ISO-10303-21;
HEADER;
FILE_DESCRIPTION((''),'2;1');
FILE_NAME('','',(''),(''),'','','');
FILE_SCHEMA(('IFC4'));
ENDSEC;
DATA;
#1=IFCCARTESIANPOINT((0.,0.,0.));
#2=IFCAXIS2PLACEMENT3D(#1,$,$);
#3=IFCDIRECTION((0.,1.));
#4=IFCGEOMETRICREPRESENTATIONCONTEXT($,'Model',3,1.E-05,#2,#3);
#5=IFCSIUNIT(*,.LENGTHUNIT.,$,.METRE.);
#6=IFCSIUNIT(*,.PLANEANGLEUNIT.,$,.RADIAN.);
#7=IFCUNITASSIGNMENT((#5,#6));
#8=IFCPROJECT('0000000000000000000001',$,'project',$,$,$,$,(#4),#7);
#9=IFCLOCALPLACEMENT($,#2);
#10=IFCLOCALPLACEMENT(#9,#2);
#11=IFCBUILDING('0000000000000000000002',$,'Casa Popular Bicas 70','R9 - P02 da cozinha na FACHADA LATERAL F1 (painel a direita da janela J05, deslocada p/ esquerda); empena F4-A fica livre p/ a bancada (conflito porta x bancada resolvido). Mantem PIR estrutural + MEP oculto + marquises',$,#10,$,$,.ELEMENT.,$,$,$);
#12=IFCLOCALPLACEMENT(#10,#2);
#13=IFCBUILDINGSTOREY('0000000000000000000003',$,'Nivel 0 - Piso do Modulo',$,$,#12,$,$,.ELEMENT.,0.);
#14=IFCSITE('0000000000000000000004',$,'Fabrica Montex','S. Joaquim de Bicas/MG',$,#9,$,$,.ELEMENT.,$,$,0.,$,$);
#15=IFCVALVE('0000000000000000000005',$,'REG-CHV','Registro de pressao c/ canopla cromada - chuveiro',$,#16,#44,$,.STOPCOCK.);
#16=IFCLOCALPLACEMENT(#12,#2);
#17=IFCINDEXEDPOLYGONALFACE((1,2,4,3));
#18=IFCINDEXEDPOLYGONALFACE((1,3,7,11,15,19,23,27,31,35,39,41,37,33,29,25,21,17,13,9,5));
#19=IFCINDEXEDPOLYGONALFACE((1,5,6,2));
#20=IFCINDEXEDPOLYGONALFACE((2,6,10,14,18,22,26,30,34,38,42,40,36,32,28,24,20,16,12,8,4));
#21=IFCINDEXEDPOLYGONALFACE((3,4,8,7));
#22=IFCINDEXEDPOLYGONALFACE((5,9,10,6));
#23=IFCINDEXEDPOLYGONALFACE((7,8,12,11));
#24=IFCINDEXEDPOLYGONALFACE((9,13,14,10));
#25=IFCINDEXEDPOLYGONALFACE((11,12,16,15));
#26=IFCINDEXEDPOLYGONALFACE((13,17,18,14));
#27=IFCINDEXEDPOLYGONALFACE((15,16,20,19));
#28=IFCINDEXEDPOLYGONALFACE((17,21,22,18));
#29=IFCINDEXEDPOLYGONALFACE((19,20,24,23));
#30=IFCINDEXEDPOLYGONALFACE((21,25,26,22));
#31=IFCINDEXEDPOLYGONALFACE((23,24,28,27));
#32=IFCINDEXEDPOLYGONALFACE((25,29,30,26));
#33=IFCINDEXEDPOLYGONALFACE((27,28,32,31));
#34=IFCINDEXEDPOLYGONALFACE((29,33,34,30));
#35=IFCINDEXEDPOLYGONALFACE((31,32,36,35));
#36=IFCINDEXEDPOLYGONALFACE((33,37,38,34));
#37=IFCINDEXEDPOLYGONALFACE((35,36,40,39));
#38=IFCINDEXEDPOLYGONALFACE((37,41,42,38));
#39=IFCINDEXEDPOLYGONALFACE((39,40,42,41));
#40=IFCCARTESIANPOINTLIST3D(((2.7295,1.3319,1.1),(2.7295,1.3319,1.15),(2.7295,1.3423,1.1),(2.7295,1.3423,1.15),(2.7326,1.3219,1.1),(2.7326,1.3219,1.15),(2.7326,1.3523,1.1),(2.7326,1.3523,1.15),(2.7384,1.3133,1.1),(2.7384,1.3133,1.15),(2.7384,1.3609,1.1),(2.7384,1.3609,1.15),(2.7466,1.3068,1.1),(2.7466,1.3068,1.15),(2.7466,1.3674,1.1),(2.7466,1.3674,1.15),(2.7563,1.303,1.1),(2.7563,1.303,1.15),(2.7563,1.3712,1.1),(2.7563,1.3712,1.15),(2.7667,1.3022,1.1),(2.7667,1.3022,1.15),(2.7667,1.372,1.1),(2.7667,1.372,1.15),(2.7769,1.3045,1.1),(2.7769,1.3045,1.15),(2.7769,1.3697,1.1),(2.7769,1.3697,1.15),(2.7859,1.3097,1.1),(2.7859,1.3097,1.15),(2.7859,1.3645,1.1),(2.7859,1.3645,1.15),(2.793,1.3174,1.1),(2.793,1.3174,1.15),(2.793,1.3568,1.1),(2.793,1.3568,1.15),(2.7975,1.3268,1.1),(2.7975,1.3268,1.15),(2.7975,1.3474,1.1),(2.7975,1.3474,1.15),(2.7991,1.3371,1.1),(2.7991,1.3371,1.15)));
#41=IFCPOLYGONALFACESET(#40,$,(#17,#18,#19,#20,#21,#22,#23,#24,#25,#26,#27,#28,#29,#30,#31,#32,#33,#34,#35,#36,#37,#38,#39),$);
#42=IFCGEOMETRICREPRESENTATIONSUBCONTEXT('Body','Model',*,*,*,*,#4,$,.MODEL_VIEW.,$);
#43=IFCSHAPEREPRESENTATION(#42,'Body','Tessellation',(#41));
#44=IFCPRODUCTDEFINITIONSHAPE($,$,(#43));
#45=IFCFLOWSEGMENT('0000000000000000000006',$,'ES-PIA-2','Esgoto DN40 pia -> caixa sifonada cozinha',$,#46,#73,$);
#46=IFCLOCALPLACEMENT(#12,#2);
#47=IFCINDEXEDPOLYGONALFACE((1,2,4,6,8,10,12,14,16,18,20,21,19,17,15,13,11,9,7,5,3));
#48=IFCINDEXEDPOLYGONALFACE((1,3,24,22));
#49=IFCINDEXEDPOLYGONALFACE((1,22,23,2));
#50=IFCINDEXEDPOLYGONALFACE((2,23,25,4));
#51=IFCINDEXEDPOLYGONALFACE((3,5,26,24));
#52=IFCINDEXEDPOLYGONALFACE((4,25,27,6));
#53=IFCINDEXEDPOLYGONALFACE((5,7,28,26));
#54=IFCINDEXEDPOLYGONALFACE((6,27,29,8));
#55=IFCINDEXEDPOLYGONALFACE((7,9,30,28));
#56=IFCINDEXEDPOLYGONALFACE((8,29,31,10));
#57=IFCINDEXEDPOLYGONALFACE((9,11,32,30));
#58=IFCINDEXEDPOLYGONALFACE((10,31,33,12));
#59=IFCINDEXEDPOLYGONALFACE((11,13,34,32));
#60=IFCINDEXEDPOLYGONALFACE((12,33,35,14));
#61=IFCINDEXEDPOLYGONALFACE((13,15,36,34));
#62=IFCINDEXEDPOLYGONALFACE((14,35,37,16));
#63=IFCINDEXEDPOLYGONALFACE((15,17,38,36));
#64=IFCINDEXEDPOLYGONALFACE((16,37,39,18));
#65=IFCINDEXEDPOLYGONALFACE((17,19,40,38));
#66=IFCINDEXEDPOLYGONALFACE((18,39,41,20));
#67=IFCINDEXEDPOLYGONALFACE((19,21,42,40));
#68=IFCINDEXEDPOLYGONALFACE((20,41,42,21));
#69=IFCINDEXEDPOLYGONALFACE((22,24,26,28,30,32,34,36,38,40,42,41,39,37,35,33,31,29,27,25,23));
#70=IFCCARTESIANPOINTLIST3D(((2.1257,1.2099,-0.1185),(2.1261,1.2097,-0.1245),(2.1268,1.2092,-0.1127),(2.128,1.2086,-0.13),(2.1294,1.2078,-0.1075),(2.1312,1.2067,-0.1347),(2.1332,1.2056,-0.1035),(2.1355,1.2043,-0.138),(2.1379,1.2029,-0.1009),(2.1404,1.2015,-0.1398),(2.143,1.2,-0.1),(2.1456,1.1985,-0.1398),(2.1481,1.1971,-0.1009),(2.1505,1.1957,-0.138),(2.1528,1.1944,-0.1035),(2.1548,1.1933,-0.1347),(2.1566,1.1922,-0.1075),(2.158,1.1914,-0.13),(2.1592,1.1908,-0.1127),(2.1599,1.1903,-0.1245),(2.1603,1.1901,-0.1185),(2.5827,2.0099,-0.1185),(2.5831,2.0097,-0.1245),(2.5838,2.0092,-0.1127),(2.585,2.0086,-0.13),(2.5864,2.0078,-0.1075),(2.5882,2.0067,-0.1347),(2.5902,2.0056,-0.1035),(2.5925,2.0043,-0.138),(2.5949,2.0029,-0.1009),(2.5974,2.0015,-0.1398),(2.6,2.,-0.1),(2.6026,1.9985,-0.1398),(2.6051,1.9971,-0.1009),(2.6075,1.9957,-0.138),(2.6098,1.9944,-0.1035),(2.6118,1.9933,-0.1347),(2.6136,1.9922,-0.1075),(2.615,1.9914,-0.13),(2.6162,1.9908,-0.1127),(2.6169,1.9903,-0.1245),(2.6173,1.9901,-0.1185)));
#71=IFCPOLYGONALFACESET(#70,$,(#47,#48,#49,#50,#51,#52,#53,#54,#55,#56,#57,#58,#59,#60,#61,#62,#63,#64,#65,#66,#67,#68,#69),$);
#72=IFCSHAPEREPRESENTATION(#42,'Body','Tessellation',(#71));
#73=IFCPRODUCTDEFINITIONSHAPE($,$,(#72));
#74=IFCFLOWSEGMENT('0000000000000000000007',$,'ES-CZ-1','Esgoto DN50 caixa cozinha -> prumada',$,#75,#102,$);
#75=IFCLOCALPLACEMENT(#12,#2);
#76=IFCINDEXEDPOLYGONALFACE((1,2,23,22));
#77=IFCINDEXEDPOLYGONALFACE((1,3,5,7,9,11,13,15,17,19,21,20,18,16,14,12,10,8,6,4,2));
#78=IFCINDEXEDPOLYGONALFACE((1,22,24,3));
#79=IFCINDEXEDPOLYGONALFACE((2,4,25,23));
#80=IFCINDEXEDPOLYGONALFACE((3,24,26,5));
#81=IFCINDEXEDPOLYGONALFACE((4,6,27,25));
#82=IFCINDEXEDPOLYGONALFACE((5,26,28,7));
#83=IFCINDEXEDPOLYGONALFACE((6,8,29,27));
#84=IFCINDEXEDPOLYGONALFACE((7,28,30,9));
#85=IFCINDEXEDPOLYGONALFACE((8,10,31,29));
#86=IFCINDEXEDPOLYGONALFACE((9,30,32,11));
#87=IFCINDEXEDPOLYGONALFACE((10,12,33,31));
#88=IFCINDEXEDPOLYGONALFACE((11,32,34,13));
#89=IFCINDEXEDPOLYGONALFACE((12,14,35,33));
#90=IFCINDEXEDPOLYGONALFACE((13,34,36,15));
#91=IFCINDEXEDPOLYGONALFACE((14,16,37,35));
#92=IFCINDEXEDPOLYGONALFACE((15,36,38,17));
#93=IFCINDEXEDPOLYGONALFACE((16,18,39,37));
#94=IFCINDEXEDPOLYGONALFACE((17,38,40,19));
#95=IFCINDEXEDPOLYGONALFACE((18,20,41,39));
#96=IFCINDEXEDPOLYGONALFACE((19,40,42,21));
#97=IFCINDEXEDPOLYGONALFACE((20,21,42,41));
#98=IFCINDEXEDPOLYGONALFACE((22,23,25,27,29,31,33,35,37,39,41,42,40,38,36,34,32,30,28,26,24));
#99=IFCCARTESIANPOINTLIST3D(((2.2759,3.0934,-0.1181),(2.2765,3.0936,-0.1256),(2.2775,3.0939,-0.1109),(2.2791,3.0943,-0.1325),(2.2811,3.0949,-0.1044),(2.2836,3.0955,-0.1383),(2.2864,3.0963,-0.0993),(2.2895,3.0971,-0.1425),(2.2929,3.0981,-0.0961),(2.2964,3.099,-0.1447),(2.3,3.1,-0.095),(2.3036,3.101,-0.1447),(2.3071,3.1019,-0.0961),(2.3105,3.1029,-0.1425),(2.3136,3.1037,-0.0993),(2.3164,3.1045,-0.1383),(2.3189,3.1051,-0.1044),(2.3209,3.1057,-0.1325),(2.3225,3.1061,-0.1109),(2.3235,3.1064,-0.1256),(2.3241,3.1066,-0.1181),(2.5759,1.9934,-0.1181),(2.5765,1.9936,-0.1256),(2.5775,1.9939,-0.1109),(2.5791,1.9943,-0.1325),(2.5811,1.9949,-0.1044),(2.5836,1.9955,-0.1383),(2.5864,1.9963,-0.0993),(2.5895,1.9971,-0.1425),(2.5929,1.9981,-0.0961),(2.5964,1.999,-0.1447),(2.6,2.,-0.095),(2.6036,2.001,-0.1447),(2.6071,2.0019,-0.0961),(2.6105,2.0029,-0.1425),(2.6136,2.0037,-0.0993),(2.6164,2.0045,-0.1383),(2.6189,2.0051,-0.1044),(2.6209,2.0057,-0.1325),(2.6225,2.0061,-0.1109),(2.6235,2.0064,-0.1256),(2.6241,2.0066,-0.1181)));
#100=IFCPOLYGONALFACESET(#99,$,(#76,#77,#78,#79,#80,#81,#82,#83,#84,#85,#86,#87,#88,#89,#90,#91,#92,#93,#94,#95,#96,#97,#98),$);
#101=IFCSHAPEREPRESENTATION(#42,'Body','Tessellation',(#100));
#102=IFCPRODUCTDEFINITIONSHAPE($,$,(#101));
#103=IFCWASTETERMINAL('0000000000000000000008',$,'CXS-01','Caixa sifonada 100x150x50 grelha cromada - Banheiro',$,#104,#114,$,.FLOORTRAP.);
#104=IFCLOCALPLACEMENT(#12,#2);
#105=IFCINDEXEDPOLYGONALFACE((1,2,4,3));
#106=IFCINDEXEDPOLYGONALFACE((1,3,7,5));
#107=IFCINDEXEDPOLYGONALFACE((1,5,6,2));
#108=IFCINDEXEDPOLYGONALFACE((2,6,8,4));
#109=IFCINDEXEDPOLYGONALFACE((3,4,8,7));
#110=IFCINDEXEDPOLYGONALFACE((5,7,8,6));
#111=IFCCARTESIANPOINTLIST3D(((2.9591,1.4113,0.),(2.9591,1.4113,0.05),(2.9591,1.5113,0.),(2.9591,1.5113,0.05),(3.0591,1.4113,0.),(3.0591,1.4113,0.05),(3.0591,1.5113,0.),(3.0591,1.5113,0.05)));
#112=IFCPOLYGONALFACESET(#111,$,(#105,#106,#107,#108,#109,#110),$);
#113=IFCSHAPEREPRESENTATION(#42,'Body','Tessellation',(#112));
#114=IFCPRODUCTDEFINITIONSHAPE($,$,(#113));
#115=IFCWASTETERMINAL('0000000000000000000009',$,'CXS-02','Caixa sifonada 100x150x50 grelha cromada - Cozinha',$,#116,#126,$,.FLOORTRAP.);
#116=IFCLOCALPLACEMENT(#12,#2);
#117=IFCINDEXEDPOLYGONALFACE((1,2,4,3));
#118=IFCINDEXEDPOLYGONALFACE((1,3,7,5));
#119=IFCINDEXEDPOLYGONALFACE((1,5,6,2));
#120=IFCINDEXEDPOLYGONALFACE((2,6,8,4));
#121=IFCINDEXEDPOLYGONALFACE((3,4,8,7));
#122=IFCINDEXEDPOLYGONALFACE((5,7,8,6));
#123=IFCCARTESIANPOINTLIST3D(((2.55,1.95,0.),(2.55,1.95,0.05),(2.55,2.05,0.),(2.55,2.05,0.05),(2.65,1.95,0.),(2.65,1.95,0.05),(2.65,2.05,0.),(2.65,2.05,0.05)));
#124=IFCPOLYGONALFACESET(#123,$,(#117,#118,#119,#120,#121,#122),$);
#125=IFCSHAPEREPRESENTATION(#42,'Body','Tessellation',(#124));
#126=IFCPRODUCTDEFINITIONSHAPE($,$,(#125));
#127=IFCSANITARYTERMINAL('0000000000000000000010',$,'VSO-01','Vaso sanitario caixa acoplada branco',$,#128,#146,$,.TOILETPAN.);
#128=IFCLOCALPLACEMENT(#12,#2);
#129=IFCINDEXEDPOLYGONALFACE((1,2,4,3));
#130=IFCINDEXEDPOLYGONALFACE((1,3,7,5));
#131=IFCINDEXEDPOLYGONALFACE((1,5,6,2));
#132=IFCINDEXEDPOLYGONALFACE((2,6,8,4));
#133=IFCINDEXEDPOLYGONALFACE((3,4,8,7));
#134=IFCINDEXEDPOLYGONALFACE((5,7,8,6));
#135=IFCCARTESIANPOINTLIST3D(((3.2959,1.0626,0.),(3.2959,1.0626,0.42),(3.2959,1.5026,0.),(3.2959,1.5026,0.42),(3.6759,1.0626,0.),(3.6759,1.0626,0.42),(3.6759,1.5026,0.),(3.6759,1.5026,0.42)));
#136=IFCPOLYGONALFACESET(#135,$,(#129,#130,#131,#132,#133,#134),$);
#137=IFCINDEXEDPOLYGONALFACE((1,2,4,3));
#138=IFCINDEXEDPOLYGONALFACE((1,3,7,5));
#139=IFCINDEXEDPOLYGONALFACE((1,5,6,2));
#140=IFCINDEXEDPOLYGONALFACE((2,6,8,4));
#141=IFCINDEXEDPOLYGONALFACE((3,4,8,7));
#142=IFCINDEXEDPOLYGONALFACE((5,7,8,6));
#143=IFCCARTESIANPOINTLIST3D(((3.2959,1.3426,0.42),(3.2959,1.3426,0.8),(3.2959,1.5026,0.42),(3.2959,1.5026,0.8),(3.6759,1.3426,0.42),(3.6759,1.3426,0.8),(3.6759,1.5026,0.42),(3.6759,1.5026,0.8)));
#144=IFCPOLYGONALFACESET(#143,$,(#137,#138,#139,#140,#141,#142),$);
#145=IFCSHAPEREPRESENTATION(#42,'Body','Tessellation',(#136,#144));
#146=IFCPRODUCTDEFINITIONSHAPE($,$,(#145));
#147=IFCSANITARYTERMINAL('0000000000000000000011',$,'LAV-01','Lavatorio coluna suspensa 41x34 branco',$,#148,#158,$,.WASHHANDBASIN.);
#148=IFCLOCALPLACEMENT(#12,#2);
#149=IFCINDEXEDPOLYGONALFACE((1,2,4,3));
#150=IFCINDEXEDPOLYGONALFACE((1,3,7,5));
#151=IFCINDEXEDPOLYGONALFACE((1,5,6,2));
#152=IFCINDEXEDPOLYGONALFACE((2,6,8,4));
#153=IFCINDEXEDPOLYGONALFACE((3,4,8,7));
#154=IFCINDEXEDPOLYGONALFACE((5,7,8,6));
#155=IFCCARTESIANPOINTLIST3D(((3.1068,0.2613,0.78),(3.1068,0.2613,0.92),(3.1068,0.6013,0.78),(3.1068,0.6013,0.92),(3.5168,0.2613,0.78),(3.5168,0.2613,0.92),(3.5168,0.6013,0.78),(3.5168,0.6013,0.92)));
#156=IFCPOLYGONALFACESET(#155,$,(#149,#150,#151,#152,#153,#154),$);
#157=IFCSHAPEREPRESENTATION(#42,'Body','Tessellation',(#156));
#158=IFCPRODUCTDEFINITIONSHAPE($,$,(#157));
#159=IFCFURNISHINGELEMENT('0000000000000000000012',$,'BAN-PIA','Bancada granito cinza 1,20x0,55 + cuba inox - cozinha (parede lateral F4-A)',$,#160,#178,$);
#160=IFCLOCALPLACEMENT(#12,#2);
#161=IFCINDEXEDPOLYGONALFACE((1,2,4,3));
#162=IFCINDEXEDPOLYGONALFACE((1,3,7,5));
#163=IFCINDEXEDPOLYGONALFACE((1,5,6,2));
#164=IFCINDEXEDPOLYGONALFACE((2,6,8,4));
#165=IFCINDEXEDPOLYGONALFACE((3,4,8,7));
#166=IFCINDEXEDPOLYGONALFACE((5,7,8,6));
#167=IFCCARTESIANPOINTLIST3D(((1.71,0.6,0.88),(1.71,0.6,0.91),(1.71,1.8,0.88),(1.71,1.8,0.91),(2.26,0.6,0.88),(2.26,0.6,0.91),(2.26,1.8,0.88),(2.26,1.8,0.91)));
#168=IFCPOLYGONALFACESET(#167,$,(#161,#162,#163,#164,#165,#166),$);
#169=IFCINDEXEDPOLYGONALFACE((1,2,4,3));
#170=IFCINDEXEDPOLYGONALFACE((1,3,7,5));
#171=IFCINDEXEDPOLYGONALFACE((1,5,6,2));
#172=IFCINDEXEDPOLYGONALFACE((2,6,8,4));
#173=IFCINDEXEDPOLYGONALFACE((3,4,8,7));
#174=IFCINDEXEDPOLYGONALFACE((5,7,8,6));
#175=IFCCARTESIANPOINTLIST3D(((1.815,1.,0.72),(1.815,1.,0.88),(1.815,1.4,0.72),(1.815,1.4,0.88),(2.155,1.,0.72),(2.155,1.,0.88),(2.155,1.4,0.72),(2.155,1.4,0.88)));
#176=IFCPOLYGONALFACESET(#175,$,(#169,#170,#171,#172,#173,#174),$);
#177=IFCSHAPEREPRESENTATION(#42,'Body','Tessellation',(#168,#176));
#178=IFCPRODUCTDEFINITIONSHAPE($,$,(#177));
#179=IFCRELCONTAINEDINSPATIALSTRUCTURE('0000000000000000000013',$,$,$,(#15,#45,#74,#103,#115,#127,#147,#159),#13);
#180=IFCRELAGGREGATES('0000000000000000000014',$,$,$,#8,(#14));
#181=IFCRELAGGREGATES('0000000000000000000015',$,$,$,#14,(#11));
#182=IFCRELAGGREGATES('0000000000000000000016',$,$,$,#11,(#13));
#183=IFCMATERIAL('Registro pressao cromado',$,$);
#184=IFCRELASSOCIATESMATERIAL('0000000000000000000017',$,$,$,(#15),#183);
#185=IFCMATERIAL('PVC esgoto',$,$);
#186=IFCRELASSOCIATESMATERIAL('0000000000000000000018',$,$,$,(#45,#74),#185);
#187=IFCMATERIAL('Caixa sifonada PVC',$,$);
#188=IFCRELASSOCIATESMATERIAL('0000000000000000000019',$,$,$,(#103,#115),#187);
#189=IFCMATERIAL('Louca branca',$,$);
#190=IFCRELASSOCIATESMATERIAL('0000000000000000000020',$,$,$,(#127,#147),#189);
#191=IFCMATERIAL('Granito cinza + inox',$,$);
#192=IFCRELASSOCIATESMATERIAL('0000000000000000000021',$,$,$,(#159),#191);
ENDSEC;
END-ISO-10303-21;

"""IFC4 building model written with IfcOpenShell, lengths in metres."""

from ifc_helpers import new_model, si_unit, direction, frame, frame_2d, origin, origin_2d, place, context, subcontext, project, spatial, rectangle, circle, extrude, material, element, save


model = new_model("IFC4")

# Units and contexts
model_context = context("Model", 3, precision=1e-05, world=origin(), true_north=direction((0.0, 1.0)))
body_context = subcontext(model_context, "Body", "Model", "MODEL_VIEW")
ifc_project = project(units=[si_unit("LENGTHUNIT", "METRE"), si_unit("PLANEANGLEUNIT", "RADIAN")], contexts=[model_context])

# Site, building, storey
site_placement = place(None, origin())
site = spatial("IfcSite", under=ifc_project, at=site_placement, Name="Fabrica Montex", Description="S. Joaquim de Bicas/MG", CompositionType="ELEMENT", RefElevation=0.0)
building_placement = place(site_placement, origin())
building = spatial("IfcBuilding", under=site, at=building_placement, Name="Casa Popular Bicas 70", Description="R9 - P02 da cozinha na FACHADA LATERAL F1 (painel a direita da janela J05, deslocada p/ esquerda); empena F4-A fica livre p/ a bancada (conflito porta x bancada resolvido). Mantem PIR estrutural + MEP oculto + marquises", CompositionType="ELEMENT")
storey_placement = place(building_placement, origin())
storey = spatial("IfcBuildingStorey", under=building, at=storey_placement, Name="Nivel 0 - Piso do Modulo", CompositionType="ELEMENT", Elevation=0.0)

# Valve
ifc_material_1 = material(Name="Registro pressao cromado")
valve_placement = place(storey_placement, frame((2.7641, 1.3371, 1.1)))
element("IfcValve", 1, at=valve_placement, inside=storey, material=ifc_material_1, Name="REG-CHV", Description="Registro de pressao c/ canopla cromada - chuveiro", PredefinedType="STOPCOCK", context=body_context, shape_type="SweptSolid", body=[
    extrude(circle(Radius=0.035, at=origin_2d()), origin(), (0.0, 0.0, 1.0), 0.05),
])

# Flow segments
ifc_material_2 = material(Name="PVC esgoto")
flow_segment_1_placement = place(storey_placement, frame((2.143, 1.2, -0.12), z_axis=(0.496022, 0.86831, 0.0), x_axis=(0.0, 0.0, 1.0)))
element("IfcFlowSegment", 2, at=flow_segment_1_placement, inside=storey, material=ifc_material_2, Name="ES-PIA-2", Description="Esgoto DN40 pia -> caixa sifonada cozinha", context=body_context, shape_type="SweptSolid", body=[
    extrude(circle(Radius=0.02, at=origin_2d()), origin(), (0.0, 0.0, 1.0), 0.9213),
])
flow_segment_2_placement = place(storey_placement, frame((2.6, 2.0, -0.12), z_axis=(-0.263117, 0.964764, 0.0), x_axis=(0.0, 0.0, 1.0)))
element("IfcFlowSegment", 3, at=flow_segment_2_placement, inside=storey, material=ifc_material_2, Name="ES-CZ-1", Description="Esgoto DN50 caixa cozinha -> prumada", context=body_context, shape_type="SweptSolid", body=[
    extrude(circle(Radius=0.025, at=origin_2d()), origin(), (0.0, 0.0, 1.0), 1.1402),
])

# Waste terminals
ifc_material_3 = material(Name="Caixa sifonada PVC")
for number, where, name, description in (
    (4, (2.9591, 1.4113, 0.0), "CXS-01", "Caixa sifonada 100x150x50 grelha cromada - Banheiro"),
    (5, (2.55, 1.95, 0.0), "CXS-02", "Caixa sifonada 100x150x50 grelha cromada - Cozinha"),
):
    element("IfcWasteTerminal", number, at=place(storey_placement, frame(where)), inside=storey, material=ifc_material_3, Name=name, Description=description, PredefinedType="FLOORTRAP", context=body_context, shape_type="SweptSolid", body=[
        extrude(rectangle(XDim=0.1, YDim=0.1, at=frame_2d((0.05, 0.05))), origin(), (0.0, 0.0, 1.0), 0.05),
    ])

# Sanitary terminals
ifc_material_4 = material(Name="Louca branca")
sanitary_terminal_1_placement = place(storey_placement, frame((3.2959, 1.0626, 0.0)))
element("IfcSanitaryTerminal", 6, at=sanitary_terminal_1_placement, inside=storey, material=ifc_material_4, Name="VSO-01", Description="Vaso sanitario caixa acoplada branco", PredefinedType="TOILETPAN", context=body_context, shape_type="SweptSolid", body=[
    extrude(rectangle(XDim=0.38, YDim=0.44, at=frame_2d((0.19, 0.22))), origin(), (0.0, 0.0, 1.0), 0.42),
    extrude(rectangle(XDim=0.38, YDim=0.16, at=frame_2d((0.19, 0.36))), frame((0.0, 0.0, 0.42)), (0.0, 0.0, 1.0), 0.38),
])
sanitary_terminal_2_placement = place(storey_placement, frame((3.1068, 0.2613, 0.78)))
element("IfcSanitaryTerminal", 7, at=sanitary_terminal_2_placement, inside=storey, material=ifc_material_4, Name="LAV-01", Description="Lavatorio coluna suspensa 41x34 branco", PredefinedType="WASHHANDBASIN", context=body_context, shape_type="SweptSolid", body=[
    extrude(rectangle(XDim=0.41, YDim=0.34, at=frame_2d((0.205, 0.17))), origin(), (0.0, 0.0, 1.0), 0.14),
])

# Furnishing element
ifc_material_5 = material(Name="Granito cinza + inox")
furnishing_placement = place(storey_placement, frame((2.26, 0.6, 0.88), x_axis=(0.0, 1.0, 0.0)))
element("IfcFurnishingElement", 8, at=furnishing_placement, inside=storey, material=ifc_material_5, Name="BAN-PIA", Description="Bancada granito cinza 1,20x0,55 + cuba inox - cozinha (parede lateral F4-A)", context=body_context, shape_type="SweptSolid", body=[
    extrude(rectangle(XDim=1.2, YDim=0.55, at=frame_2d((0.6, 0.275))), origin(), (0.0, 0.0, 1.0), 0.03),
    extrude(rectangle(XDim=0.4, YDim=0.34, at=frame_2d((0.6, 0.275))), frame((0.0, 0.0, -0.16)), (0.0, 0.0, 1.0), 0.16),
])

save(model, "model.ifc")
